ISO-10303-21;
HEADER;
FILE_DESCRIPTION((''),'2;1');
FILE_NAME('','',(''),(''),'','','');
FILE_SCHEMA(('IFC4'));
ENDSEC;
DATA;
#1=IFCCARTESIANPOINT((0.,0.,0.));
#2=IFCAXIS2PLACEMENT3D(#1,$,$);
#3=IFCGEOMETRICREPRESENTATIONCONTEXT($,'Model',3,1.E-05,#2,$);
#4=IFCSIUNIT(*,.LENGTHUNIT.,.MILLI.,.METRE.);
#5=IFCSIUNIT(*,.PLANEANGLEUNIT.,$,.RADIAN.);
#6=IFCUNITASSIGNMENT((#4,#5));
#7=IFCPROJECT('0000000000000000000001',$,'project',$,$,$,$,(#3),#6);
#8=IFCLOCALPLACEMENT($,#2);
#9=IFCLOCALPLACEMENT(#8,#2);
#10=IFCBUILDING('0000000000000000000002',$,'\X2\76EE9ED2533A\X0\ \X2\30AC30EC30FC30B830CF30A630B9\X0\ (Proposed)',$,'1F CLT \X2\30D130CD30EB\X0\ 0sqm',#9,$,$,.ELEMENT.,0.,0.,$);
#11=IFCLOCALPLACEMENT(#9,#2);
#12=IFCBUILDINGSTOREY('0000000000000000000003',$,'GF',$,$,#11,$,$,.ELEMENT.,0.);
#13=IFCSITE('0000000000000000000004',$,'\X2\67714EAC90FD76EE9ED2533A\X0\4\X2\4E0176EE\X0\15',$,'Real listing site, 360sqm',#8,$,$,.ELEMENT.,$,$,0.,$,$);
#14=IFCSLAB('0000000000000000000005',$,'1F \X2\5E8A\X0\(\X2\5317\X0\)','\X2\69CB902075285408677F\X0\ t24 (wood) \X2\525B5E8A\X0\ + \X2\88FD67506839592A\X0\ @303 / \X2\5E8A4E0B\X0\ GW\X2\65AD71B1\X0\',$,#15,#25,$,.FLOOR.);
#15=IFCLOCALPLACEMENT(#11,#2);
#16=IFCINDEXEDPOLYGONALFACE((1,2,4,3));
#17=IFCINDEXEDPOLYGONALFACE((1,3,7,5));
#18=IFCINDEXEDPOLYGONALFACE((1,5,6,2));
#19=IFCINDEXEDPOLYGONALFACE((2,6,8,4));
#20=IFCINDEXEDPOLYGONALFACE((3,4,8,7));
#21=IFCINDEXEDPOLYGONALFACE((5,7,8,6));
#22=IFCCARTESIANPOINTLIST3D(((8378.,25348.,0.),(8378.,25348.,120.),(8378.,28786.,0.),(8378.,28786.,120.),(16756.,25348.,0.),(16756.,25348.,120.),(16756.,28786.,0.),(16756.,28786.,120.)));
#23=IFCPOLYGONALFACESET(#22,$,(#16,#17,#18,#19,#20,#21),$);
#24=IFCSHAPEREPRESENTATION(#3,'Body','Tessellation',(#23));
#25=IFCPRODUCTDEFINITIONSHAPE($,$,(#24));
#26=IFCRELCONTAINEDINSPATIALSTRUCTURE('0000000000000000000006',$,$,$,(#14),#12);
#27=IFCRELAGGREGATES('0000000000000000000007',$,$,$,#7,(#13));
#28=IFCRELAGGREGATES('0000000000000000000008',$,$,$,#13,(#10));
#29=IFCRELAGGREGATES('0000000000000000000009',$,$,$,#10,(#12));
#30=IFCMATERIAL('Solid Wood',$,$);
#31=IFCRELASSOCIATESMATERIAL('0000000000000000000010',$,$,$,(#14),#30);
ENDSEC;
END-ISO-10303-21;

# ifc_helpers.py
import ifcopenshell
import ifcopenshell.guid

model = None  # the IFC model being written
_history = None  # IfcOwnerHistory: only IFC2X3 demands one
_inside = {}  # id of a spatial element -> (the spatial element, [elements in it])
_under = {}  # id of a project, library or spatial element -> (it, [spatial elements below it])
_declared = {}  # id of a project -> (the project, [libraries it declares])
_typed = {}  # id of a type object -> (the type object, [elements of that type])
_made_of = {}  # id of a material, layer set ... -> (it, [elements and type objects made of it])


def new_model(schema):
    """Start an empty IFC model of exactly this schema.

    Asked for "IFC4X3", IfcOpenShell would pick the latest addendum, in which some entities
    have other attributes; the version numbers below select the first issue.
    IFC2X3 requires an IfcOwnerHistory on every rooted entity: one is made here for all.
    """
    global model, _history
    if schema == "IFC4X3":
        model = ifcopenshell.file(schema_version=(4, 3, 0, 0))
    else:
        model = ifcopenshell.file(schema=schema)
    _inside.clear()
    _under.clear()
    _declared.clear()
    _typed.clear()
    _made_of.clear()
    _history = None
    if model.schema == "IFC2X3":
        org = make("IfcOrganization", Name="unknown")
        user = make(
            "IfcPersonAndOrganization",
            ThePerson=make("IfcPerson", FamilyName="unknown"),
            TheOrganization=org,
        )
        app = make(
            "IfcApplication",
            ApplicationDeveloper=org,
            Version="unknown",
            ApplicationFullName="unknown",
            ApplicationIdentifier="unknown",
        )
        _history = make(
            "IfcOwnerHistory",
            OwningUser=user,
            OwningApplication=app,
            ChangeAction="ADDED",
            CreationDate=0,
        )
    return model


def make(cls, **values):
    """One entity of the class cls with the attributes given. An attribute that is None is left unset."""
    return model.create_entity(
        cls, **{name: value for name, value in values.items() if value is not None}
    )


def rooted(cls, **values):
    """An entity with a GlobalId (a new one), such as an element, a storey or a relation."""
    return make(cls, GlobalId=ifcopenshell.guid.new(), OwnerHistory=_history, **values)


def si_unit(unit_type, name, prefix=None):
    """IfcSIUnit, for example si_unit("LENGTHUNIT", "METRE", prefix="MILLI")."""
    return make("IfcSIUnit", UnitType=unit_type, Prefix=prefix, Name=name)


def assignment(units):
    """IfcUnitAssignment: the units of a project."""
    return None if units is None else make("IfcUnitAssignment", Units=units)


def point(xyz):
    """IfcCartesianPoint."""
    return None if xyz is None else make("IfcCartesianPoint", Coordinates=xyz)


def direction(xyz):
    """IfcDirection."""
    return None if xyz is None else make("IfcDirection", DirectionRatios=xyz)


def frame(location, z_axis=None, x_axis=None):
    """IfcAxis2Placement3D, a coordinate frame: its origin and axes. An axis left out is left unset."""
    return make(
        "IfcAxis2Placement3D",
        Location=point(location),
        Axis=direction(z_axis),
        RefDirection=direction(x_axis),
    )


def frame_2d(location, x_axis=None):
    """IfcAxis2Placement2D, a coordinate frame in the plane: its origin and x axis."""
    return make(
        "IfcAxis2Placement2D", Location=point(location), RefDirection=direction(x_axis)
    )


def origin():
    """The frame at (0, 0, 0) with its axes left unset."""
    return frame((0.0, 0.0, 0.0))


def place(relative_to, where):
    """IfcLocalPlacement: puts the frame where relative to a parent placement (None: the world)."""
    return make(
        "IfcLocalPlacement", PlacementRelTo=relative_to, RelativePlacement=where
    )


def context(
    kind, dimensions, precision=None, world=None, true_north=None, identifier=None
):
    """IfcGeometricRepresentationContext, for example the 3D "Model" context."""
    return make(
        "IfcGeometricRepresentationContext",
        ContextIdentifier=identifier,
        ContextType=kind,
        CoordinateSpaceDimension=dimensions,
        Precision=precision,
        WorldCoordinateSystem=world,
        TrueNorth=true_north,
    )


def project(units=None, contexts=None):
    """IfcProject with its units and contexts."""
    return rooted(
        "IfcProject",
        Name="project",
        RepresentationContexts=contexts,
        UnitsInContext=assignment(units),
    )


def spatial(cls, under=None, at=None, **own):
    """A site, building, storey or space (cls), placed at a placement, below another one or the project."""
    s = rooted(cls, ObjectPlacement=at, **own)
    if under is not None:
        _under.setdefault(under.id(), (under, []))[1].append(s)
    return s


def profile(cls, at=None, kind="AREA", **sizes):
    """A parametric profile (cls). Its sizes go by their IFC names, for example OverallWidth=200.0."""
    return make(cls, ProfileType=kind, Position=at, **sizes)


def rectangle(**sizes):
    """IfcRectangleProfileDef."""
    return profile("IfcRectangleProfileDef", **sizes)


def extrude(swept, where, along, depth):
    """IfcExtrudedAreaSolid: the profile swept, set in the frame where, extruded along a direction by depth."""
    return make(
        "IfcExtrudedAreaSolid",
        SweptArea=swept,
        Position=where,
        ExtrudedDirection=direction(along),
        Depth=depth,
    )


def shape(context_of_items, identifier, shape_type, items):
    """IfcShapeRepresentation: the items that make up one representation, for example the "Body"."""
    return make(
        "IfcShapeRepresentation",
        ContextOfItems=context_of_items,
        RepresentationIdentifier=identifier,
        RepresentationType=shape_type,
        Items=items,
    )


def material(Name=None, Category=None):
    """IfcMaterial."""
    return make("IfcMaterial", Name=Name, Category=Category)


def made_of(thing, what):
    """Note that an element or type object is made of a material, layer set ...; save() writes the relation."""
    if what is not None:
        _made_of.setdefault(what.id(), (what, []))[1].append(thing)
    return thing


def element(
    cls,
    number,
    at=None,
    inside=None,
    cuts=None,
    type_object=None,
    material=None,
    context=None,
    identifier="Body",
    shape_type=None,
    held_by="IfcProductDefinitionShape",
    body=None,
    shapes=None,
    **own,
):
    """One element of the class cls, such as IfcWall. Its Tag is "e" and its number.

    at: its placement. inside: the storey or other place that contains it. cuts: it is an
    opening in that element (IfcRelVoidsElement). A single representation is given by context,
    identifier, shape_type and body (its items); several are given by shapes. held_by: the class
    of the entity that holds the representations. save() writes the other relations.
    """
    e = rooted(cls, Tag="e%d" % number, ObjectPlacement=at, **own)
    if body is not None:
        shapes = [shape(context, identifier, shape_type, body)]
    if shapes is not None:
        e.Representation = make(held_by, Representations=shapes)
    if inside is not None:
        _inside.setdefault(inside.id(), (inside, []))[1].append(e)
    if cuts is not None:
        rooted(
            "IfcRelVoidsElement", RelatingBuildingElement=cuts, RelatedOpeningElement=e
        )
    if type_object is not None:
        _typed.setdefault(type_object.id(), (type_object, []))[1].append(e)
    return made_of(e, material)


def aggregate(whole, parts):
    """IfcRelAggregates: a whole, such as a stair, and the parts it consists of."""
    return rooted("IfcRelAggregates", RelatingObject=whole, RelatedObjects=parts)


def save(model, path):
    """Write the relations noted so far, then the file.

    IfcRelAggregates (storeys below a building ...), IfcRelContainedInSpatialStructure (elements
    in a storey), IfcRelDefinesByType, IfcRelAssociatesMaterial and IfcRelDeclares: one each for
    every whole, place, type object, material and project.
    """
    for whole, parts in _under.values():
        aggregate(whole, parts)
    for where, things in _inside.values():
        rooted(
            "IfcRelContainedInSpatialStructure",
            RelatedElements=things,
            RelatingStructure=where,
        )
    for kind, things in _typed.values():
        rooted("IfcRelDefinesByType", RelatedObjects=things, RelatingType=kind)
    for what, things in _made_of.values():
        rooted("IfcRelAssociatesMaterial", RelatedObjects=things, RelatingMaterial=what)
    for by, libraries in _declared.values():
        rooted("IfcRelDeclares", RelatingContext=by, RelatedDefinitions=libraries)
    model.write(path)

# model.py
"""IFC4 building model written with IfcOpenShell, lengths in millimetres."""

from ifc_helpers import new_model, si_unit, frame, frame_2d, origin, place, context, project, spatial, rectangle, extrude, material, element, save


model = new_model("IFC4")

# Units and contexts
model_context = context("Model", 3, precision=1e-05, world=origin())
ifc_project = project(units=[si_unit("LENGTHUNIT", "METRE", prefix="MILLI"), si_unit("PLANEANGLEUNIT", "RADIAN")], contexts=[model_context])

# Site, building, storey
site_placement = place(None, origin())
site = spatial("IfcSite", under=ifc_project, at=site_placement, Name="東京都目黒区4丁目15", ObjectType="Real listing site, 360sqm", CompositionType="ELEMENT", RefElevation=0.0)
building_placement = place(site_placement, origin())
building = spatial("IfcBuilding", under=site, at=building_placement, Name="目黒区 ガレージハウス (Proposed)", ObjectType="1F CLT パネル 0sqm", CompositionType="ELEMENT", ElevationOfRefHeight=0.0, ElevationOfTerrain=0.0)
storey_placement = place(building_placement, origin())
storey = spatial("IfcBuildingStorey", under=building, at=storey_placement, Name="GF", CompositionType="ELEMENT", Elevation=0.0)

# Slab
ifc_material_1 = material(Name="Solid Wood")
slab_1_placement = place(storey_placement, frame((4189.0, 12674.0, 0.0)))
element("IfcSlab", 1, at=slab_1_placement, inside=storey, material=ifc_material_1, Name="1F 床(北)", Description="構造用合板 t24 (wood) 剛床 + 製材根太 @303 / 床下 GW断熱", PredefinedType="FLOOR", context=model_context, shape_type="SweptSolid", body=[
    extrude(rectangle(XDim=8378.0, YDim=3438.0, at=frame_2d((4189.0, 1719.0))), frame((4189.0, 12674.0, 0.0)), (0.0, 0.0, 1.0), 120.0),
])

save(model, "model.ifc")
